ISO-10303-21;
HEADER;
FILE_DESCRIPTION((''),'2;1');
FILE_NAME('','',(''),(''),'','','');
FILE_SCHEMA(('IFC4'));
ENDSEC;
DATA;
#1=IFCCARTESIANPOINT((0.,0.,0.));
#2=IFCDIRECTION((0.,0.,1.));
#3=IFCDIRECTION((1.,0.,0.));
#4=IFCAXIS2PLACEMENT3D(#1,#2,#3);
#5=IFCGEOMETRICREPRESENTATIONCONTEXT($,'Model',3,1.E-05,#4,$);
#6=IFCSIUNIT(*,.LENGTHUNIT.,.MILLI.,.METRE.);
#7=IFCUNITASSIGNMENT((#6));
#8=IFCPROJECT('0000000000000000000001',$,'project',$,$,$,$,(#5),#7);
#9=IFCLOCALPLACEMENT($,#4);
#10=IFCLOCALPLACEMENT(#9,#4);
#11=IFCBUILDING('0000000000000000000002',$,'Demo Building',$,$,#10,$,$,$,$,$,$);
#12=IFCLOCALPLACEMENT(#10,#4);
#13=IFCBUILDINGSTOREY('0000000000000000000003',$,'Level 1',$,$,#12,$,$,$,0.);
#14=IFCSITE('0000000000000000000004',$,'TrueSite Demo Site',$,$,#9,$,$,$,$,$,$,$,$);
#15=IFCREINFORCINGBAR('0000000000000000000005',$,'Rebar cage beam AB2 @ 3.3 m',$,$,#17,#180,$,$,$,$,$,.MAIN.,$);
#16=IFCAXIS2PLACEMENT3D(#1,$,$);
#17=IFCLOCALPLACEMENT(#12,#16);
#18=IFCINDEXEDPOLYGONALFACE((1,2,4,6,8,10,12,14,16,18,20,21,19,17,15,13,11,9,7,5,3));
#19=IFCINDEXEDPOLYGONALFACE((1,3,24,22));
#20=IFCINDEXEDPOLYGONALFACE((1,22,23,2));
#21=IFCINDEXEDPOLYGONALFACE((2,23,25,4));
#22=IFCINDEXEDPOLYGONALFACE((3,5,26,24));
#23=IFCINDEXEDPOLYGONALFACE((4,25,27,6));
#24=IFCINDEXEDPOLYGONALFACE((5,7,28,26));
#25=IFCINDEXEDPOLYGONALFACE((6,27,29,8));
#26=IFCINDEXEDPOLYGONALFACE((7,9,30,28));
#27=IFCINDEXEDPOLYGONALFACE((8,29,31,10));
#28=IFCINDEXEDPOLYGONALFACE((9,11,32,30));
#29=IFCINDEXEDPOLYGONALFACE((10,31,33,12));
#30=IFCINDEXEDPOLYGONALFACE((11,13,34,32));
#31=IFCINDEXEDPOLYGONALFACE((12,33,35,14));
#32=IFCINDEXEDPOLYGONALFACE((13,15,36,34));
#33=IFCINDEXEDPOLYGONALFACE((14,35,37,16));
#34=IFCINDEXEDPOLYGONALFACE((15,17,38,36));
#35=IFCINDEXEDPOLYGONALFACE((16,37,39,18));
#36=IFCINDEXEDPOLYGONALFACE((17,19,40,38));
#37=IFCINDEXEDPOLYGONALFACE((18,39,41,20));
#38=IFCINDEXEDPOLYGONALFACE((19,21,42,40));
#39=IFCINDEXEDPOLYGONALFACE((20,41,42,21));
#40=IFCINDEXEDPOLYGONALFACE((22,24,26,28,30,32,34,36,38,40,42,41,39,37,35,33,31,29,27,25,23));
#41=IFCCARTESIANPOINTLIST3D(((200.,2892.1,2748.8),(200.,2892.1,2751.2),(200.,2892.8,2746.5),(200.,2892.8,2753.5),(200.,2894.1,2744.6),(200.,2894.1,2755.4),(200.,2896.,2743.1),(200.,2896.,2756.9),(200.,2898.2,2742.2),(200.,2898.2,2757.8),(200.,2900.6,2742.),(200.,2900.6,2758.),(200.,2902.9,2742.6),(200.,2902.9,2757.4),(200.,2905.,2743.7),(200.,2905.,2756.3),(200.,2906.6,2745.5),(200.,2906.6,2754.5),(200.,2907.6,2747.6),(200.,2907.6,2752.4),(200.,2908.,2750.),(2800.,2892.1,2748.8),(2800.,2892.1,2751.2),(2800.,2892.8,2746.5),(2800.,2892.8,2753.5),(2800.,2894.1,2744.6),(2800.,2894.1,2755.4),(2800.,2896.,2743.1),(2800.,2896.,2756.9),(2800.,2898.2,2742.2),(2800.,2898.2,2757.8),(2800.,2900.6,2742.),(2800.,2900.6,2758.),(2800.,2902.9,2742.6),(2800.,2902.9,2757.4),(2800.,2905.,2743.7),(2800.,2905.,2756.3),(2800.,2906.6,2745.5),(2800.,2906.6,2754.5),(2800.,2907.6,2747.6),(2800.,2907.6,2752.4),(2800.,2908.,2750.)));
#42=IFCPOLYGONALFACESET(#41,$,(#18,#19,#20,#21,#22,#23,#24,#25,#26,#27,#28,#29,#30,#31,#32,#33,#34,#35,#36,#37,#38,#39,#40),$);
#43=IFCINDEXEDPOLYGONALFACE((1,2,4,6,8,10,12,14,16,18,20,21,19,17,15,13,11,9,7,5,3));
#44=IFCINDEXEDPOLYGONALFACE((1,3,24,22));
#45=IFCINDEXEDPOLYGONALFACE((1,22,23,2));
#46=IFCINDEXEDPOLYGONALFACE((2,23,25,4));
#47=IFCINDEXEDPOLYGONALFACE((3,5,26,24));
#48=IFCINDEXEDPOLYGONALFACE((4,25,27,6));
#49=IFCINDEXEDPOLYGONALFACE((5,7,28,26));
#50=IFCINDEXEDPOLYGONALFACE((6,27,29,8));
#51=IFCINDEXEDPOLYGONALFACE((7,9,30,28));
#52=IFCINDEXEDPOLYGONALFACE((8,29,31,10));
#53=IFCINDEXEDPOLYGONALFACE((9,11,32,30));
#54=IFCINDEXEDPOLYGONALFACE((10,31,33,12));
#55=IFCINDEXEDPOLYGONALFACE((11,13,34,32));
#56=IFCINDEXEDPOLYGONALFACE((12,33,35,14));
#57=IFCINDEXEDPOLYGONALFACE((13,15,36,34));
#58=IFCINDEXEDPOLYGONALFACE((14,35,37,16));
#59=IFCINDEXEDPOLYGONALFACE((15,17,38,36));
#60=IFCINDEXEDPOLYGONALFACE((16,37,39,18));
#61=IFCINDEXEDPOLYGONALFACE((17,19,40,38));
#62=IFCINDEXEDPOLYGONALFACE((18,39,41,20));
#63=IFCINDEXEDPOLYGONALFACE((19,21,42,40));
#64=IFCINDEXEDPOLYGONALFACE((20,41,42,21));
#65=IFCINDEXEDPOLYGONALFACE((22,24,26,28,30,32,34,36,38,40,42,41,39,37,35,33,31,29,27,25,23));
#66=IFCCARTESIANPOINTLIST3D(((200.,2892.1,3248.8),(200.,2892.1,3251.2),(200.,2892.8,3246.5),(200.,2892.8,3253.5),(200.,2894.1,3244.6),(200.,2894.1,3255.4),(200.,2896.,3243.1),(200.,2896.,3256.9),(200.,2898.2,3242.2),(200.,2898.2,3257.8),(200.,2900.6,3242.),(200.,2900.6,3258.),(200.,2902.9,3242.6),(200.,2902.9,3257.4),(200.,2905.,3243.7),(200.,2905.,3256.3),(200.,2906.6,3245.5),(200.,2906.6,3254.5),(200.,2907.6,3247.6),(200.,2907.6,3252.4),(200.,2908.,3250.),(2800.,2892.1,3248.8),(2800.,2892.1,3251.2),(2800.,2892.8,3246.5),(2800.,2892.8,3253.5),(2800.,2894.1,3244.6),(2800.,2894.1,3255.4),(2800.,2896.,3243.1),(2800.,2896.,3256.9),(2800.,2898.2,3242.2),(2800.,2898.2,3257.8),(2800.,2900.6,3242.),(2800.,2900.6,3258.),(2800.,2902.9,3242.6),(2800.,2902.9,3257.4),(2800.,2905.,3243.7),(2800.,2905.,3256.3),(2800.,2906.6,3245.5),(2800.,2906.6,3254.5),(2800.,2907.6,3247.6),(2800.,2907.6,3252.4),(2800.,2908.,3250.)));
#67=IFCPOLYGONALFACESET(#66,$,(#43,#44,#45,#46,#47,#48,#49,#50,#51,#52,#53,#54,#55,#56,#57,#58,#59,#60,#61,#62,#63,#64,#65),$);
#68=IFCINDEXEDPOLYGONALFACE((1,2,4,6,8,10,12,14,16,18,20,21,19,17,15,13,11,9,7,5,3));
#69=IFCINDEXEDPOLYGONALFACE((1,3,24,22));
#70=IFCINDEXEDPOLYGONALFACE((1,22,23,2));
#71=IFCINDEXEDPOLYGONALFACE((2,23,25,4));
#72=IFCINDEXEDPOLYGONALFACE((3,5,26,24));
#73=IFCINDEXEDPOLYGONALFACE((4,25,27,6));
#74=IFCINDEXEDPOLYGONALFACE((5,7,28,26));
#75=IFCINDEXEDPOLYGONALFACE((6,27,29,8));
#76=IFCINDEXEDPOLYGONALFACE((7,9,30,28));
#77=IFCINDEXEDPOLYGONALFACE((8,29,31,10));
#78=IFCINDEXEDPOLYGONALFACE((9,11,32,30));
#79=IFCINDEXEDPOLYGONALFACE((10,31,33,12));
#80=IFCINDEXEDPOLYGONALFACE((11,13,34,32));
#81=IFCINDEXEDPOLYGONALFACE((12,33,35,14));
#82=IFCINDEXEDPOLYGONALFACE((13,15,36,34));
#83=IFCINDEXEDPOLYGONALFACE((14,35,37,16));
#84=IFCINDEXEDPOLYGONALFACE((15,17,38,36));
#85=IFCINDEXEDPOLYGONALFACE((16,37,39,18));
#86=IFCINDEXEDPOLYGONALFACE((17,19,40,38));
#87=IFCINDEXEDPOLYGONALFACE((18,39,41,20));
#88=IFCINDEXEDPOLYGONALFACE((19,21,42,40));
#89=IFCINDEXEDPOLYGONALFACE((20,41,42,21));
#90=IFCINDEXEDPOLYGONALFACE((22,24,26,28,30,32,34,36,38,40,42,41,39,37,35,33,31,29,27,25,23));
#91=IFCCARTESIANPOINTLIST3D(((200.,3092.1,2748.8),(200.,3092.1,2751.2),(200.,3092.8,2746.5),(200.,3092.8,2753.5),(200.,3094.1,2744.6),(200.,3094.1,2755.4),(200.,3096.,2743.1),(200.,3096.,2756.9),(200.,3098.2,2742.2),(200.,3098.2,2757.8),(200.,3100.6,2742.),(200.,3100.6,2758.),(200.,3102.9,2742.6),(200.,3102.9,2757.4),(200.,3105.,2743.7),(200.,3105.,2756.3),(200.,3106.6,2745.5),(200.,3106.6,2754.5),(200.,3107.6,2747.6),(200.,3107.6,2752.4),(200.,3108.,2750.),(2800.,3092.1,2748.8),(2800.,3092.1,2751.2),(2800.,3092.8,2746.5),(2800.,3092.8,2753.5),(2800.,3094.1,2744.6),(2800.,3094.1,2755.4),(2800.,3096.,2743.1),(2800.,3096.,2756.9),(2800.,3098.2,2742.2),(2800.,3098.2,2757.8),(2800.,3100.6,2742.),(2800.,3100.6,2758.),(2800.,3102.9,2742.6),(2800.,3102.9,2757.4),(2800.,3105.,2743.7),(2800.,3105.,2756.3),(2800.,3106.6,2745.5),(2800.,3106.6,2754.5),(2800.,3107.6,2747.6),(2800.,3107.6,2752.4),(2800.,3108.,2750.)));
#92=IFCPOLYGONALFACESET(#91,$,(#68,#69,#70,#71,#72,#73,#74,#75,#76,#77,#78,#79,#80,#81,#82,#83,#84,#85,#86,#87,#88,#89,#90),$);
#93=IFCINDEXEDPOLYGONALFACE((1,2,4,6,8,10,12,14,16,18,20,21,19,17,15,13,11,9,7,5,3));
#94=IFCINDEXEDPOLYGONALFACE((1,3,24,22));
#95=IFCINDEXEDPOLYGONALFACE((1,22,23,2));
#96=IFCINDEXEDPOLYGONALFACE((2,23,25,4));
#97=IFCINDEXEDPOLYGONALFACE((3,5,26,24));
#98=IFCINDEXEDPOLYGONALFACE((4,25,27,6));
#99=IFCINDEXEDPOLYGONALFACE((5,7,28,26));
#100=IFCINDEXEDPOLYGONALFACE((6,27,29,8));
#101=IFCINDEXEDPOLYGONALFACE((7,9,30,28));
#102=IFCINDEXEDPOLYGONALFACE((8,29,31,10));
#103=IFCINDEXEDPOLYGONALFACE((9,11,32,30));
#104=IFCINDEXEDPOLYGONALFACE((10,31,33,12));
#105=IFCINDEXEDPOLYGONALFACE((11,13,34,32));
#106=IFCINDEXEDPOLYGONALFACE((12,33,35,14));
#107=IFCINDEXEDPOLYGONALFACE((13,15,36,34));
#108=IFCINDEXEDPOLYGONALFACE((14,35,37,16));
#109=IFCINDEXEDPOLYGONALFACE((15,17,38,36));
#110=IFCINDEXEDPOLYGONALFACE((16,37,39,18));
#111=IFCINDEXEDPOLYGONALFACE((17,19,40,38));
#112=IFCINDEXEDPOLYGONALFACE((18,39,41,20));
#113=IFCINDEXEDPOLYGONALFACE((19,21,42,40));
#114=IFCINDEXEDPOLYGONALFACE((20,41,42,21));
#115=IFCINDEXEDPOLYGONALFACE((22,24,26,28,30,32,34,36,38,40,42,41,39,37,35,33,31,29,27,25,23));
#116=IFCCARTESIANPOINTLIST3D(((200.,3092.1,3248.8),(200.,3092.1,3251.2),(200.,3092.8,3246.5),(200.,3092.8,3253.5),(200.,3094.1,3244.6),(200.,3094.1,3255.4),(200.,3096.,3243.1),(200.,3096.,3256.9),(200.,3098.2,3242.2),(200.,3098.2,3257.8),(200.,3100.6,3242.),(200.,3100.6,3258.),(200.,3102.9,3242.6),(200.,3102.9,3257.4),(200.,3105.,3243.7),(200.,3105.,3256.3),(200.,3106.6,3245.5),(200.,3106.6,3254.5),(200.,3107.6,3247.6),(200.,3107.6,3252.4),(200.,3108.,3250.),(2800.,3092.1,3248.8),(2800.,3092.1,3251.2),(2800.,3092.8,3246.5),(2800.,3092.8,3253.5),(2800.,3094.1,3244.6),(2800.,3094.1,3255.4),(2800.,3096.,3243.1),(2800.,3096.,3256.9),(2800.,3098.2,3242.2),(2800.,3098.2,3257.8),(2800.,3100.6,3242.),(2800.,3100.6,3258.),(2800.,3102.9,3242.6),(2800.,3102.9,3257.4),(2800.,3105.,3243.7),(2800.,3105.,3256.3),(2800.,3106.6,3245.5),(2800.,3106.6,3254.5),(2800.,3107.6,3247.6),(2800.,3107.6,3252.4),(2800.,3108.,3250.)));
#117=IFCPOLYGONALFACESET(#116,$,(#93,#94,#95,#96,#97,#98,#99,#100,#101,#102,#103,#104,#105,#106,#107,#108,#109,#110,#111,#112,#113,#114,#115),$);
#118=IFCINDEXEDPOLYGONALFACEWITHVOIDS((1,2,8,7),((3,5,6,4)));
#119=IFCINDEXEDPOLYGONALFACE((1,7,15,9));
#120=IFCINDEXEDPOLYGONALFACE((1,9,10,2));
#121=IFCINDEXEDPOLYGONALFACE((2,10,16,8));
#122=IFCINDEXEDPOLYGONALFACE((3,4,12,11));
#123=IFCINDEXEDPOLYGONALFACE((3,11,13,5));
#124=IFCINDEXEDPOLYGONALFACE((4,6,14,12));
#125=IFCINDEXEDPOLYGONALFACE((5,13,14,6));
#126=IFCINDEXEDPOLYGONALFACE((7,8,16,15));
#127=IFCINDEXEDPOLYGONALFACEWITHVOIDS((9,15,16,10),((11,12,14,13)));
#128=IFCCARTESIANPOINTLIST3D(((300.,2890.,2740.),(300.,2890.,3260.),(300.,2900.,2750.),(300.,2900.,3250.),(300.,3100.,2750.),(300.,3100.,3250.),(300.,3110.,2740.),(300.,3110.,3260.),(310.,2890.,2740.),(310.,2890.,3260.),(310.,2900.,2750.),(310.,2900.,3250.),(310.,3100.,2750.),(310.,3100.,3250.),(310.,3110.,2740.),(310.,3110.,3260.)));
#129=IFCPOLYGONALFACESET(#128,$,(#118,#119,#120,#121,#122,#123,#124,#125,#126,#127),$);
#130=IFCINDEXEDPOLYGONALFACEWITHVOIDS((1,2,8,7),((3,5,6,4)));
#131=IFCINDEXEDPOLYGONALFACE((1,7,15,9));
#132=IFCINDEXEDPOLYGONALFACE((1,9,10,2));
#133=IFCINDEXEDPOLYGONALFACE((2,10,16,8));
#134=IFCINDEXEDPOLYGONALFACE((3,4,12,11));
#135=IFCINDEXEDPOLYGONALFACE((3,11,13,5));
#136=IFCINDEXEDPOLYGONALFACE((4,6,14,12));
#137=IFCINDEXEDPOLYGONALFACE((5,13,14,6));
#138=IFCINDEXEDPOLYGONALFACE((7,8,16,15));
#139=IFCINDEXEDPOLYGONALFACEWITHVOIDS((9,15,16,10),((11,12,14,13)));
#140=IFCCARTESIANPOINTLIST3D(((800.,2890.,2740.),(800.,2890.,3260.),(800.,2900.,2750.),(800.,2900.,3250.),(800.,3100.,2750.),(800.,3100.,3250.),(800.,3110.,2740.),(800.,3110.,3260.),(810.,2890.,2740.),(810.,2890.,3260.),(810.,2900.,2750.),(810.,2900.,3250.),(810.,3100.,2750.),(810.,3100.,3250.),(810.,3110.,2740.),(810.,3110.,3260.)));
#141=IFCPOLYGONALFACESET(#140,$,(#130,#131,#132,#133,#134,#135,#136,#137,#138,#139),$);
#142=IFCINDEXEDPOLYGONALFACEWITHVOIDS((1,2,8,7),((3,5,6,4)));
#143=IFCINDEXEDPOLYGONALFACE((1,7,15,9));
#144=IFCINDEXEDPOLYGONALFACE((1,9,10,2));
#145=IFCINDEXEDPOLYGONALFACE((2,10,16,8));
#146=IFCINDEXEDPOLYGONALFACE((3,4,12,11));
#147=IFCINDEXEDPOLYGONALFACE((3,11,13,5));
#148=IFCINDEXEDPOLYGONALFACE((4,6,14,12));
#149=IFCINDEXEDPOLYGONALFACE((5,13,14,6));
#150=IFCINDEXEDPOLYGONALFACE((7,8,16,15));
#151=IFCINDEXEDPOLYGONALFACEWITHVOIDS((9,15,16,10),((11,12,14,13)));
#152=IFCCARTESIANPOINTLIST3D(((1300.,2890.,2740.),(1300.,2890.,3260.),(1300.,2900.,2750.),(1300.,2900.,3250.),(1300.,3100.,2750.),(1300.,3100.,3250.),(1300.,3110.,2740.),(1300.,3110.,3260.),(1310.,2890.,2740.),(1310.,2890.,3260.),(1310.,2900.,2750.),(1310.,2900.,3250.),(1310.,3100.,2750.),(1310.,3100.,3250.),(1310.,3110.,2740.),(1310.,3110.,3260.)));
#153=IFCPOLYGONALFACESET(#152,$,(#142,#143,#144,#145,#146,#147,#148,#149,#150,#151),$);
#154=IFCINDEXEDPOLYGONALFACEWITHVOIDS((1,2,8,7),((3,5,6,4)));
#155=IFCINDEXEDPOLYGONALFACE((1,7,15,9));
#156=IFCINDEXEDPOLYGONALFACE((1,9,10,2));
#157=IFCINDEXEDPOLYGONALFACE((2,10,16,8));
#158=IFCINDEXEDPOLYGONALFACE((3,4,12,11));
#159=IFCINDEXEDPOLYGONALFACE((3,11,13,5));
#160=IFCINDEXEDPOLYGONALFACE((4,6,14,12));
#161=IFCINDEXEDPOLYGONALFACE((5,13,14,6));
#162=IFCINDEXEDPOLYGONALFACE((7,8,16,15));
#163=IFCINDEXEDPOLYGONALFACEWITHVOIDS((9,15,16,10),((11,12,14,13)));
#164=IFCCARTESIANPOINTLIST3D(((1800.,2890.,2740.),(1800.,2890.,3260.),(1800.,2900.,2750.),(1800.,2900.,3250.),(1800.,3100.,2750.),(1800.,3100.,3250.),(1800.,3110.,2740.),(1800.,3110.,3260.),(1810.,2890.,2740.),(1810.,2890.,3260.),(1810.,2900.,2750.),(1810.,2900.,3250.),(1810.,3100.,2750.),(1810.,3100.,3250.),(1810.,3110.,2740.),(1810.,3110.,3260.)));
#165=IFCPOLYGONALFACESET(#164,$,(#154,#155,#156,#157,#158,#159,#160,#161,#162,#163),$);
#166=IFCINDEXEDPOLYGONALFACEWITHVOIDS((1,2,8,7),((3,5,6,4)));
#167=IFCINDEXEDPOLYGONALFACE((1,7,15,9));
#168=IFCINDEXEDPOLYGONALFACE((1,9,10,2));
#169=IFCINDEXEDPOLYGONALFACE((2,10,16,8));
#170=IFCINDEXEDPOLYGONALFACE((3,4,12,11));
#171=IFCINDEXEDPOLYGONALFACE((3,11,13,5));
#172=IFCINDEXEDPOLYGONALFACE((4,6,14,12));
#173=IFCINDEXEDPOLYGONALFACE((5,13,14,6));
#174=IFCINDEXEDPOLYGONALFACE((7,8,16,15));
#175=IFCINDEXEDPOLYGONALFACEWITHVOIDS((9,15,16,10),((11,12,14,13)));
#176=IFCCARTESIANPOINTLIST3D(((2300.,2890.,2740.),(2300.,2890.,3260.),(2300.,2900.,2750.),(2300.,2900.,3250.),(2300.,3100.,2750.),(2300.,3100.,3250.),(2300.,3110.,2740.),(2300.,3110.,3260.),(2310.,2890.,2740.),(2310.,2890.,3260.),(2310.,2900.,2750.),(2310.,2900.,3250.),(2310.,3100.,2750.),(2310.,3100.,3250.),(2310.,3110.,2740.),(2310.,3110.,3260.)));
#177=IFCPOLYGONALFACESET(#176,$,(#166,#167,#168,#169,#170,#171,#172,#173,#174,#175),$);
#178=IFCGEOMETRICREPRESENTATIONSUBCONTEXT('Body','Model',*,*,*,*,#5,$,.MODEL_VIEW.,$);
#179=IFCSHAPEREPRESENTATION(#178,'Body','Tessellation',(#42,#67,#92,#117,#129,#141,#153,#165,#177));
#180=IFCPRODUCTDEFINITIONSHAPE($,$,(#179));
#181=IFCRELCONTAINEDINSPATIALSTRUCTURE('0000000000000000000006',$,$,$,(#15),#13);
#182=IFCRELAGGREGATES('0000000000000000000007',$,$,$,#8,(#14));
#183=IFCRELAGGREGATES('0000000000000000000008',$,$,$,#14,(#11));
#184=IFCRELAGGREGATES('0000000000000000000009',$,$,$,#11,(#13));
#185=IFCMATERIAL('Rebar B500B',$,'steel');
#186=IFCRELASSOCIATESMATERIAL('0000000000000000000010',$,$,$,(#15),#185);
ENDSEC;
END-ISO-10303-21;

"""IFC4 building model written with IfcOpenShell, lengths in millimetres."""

from ifc_helpers import new_model, si_unit, frame, origin_with_axes, place, context, subcontext, project, spatial, hollow_rectangle, circle, extrude, material, element, save


model = new_model("IFC4")

# Units and contexts
model_context = context("Model", 3, precision=1e-05, world=origin_with_axes())
body_context = subcontext(model_context, "Body", "Model", "MODEL_VIEW")
ifc_project = project(units=[si_unit("LENGTHUNIT", "METRE", prefix="MILLI")], contexts=[model_context])

# Site, building, storey
site_placement = place(None, origin_with_axes())
site = spatial("IfcSite", under=ifc_project, at=site_placement, Name="TrueSite Demo Site")
building_placement = place(site_placement, origin_with_axes())
building = spatial("IfcBuilding", under=site, at=building_placement, Name="Demo Building")
storey_placement = place(building_placement, origin_with_axes())
storey = spatial("IfcBuildingStorey", under=building, at=storey_placement, Name="Level 1", Elevation=0.0)

# Reinforcing bar
ifc_material_1 = material(Name="Rebar B500B", Category="steel")
for number, where, z_axis, x_axis, name in (
    (1, (200.0, 3000.0, 3000.0), (1.0, 0.0, 0.0), (0.0, 1.0, 0.0), "Rebar cage beam AB2 @ 3.3 m"),
):
    element("IfcReinforcingBar", number, at=place(storey_placement, frame(where, z_axis=z_axis, x_axis=x_axis)), inside=storey, material=ifc_material_1, Name=name, PredefinedType="MAIN", context=body_context, shape_type="SweptSolid", body=[
        extrude(circle(Radius=8.0), frame((-100.0, -250.0, 0.0)), (0.0, 0.0, 1.0), 2600.0),
        extrude(circle(Radius=8.0), frame((-100.0, 250.0, 0.0)), (0.0, 0.0, 1.0), 2600.0),
        extrude(circle(Radius=8.0), frame((100.0, -250.0, 0.0)), (0.0, 0.0, 1.0), 2600.0),
        extrude(circle(Radius=8.0), frame((100.0, 250.0, 0.0)), (0.0, 0.0, 1.0), 2600.0),
        extrude(hollow_rectangle(XDim=220.0, YDim=520.0, WallThickness=10.0), frame((0.0, 0.0, 100.0)), (0.0, 0.0, 1.0), 10.0),
        extrude(hollow_rectangle(XDim=220.0, YDim=520.0, WallThickness=10.0), frame((0.0, 0.0, 600.0)), (0.0, 0.0, 1.0), 10.0),
        extrude(hollow_rectangle(XDim=220.0, YDim=520.0, WallThickness=10.0), frame((0.0, 0.0, 1100.0)), (0.0, 0.0, 1.0), 10.0),
        extrude(hollow_rectangle(XDim=220.0, YDim=520.0, WallThickness=10.0), frame((0.0, 0.0, 1600.0)), (0.0, 0.0, 1.0), 10.0),
        extrude(hollow_rectangle(XDim=220.0, YDim=520.0, WallThickness=10.0), frame((0.0, 0.0, 2100.0)), (0.0, 0.0, 1.0), 10.0),
    ])

save(model, "model.ifc")
